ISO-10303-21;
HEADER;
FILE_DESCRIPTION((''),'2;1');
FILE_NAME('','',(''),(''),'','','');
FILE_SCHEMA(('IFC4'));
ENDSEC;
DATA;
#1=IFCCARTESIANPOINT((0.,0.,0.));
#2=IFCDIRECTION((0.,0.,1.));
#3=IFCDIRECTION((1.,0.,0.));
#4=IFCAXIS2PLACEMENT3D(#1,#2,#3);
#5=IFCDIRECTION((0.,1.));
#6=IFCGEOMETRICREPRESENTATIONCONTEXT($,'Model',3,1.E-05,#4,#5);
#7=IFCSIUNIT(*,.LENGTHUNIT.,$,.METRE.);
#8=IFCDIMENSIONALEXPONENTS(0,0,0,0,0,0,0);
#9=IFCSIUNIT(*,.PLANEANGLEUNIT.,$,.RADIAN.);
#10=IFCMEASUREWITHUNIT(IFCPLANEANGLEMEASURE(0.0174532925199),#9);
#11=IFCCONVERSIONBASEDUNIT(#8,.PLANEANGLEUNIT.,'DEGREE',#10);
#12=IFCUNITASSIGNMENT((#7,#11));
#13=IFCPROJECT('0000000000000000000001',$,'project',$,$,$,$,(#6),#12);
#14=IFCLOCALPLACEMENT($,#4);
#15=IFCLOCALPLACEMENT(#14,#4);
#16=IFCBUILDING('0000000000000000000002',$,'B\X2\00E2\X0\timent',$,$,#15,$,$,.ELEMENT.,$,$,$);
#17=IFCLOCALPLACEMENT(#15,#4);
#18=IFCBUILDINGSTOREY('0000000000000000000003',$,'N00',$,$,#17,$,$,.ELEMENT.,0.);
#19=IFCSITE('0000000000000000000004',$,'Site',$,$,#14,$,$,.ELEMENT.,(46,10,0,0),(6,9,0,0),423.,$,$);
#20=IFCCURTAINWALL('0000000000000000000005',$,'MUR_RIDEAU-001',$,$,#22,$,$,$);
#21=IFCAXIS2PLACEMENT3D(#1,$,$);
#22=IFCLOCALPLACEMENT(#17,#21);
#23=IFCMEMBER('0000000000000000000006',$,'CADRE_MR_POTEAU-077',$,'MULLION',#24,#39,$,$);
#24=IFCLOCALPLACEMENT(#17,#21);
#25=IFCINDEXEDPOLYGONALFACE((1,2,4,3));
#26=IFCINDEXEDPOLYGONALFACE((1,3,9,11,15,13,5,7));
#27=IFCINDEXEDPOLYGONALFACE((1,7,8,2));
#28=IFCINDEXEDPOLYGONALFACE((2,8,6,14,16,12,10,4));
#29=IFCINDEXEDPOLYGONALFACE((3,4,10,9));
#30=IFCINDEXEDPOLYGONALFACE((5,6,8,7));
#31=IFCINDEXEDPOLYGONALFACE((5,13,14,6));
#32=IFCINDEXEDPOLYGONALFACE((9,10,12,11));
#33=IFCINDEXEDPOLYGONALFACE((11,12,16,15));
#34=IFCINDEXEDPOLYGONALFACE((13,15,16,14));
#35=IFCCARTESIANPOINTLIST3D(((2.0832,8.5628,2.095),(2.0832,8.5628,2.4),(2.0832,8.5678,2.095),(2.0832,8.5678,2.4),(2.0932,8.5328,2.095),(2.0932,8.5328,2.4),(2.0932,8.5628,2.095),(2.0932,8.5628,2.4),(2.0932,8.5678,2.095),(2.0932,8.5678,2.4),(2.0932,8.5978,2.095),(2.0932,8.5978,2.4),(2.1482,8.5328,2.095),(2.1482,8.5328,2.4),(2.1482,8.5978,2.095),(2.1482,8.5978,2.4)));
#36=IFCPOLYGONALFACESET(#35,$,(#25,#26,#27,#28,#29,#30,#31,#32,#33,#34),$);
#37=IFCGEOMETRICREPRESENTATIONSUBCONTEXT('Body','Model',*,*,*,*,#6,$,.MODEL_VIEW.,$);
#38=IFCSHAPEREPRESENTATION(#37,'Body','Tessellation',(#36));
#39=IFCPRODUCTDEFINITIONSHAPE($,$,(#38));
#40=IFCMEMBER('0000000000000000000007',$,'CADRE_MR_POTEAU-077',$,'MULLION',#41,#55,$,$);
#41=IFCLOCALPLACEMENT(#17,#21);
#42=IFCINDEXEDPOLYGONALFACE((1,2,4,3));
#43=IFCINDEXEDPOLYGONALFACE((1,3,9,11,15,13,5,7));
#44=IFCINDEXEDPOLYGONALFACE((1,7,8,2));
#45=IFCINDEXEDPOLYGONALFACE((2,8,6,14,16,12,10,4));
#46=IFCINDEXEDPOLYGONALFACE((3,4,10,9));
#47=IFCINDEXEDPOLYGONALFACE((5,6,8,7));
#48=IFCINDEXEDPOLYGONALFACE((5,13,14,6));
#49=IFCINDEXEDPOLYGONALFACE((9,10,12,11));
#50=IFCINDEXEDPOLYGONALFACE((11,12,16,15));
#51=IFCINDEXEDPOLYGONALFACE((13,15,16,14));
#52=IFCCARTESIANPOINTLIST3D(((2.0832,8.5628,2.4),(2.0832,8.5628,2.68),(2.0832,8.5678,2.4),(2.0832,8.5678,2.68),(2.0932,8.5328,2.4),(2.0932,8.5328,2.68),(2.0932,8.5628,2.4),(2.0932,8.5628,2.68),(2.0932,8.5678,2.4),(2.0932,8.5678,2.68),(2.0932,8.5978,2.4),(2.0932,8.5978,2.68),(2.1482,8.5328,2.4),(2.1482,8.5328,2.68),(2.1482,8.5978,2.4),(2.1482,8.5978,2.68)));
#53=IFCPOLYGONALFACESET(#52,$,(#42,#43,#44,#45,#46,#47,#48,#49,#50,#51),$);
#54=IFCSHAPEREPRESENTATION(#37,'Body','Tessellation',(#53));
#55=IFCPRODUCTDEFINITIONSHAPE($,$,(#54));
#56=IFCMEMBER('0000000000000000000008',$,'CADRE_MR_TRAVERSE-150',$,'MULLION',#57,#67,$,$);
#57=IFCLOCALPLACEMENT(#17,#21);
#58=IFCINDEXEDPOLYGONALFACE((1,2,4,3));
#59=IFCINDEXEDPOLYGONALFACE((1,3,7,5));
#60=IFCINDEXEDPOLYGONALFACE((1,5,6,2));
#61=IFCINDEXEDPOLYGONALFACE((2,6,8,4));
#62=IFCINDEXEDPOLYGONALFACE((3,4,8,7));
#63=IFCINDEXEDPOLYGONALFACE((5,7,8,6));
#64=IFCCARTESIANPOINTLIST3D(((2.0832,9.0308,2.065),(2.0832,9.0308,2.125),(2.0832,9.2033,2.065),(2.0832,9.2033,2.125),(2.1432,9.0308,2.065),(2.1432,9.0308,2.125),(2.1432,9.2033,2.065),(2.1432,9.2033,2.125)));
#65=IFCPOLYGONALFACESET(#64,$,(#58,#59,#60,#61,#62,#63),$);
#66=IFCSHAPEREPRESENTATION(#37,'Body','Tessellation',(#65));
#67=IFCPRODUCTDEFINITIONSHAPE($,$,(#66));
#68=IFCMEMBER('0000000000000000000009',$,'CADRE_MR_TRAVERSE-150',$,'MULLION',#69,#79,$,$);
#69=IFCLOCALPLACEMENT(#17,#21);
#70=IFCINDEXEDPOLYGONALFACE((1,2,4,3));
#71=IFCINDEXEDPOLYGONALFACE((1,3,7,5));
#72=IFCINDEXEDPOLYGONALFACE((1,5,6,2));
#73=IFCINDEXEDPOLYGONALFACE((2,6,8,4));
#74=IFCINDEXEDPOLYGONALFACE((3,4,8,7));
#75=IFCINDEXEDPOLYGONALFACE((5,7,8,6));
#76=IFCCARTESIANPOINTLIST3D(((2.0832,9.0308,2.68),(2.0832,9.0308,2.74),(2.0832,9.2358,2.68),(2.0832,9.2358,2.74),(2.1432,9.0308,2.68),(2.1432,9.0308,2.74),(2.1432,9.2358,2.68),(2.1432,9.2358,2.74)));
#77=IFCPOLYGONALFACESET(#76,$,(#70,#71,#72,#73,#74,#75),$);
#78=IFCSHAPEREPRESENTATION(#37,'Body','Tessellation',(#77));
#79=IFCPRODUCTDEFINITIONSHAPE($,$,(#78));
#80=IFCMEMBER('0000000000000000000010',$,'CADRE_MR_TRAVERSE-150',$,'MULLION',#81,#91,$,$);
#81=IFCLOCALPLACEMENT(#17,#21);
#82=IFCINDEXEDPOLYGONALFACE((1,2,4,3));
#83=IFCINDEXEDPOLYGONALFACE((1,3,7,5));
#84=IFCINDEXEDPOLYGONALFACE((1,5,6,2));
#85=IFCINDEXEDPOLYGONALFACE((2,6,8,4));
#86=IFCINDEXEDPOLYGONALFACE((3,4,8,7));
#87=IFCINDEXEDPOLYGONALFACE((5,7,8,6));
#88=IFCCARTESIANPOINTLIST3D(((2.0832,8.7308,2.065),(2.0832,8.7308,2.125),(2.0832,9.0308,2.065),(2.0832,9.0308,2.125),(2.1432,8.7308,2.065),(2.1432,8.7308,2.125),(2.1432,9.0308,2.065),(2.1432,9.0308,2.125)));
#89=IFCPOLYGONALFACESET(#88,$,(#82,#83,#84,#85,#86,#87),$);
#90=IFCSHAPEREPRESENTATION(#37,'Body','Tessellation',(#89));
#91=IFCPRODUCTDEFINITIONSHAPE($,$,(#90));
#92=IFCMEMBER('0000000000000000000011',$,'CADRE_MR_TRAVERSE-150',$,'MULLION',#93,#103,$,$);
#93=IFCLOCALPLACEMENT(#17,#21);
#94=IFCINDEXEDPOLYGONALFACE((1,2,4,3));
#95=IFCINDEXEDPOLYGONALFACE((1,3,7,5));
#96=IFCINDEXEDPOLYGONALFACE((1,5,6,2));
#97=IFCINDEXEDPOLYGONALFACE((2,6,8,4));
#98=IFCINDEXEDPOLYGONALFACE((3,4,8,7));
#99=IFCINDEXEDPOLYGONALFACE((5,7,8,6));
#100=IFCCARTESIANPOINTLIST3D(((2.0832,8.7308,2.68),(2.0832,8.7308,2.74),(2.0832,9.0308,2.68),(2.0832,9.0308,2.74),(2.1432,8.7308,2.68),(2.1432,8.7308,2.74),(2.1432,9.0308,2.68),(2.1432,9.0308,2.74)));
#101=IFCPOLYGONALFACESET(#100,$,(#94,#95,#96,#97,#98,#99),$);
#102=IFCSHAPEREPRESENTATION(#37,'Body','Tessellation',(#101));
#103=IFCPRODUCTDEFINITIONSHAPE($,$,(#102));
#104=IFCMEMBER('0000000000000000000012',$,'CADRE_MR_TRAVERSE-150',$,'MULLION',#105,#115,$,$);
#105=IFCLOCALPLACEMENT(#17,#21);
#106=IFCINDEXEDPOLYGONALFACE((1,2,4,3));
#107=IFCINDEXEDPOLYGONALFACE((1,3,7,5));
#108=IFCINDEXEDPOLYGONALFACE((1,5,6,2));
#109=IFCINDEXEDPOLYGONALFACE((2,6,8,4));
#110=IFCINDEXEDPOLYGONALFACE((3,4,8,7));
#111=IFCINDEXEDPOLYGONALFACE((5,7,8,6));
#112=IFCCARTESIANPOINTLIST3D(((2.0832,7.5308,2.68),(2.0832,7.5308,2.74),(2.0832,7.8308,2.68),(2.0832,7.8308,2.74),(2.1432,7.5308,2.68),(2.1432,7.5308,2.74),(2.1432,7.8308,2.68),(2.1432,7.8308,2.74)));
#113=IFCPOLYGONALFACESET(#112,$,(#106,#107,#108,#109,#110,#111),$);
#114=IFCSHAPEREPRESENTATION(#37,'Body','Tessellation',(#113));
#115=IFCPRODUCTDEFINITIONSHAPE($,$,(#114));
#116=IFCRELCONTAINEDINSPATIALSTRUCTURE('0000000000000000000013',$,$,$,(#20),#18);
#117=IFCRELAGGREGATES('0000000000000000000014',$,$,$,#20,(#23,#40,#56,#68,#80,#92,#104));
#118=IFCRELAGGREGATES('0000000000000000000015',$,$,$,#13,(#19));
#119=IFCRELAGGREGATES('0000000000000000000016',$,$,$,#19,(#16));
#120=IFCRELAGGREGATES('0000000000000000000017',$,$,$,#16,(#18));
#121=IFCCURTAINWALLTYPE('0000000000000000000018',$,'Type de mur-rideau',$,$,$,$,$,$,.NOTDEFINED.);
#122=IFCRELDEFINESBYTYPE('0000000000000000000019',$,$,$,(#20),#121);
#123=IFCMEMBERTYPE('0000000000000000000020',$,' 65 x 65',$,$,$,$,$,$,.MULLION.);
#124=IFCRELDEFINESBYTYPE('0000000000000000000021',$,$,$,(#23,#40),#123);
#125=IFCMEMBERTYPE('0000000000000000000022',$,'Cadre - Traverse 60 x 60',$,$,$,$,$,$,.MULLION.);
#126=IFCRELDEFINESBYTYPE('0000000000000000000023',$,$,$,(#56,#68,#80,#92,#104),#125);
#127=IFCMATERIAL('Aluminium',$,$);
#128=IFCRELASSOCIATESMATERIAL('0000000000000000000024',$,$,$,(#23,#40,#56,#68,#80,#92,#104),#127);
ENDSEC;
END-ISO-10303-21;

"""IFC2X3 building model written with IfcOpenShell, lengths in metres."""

from ifc_helpers import new_model, entity, si_unit, converted_unit, direction, frame, origin_with_axes, place, context, subcontext, project, spatial, polyline, outline, extrude, material, type_object, element, aggregate, save


model = new_model("IFC2X3")

# Units and contexts
model_context = context("Model", 3, precision=1e-05, world=origin_with_axes(), true_north=direction((0.0, 1.0)))
body_context = subcontext(model_context, "Body", "Model", "MODEL_VIEW")
ifc_project = project(units=[si_unit("LENGTHUNIT", "METRE"), converted_unit("PLANEANGLEUNIT", "DEGREE", entity("IfcPlaneAngleMeasure", 0.0174532925199), si_unit("PLANEANGLEUNIT", "RADIAN"), dimensions=[0, 0, 0, 0, 0, 0, 0])], contexts=[model_context])

# Site, building, storey
site_placement = place(None, origin_with_axes())
site = spatial("IfcSite", under=ifc_project, at=site_placement, Name="Site", CompositionType="ELEMENT", RefLatitude=(46, 10, 0, 0), RefLongitude=(6, 9, 0, 0), RefElevation=423.0)
building_placement = place(site_placement, origin_with_axes())
building = spatial("IfcBuilding", under=site, at=building_placement, Name="Bâtiment", CompositionType="ELEMENT")
storey_placement = place(building_placement, origin_with_axes())
storey = spatial("IfcBuildingStorey", under=building, at=storey_placement, Name="N00", CompositionType="ELEMENT", Elevation=0.0)

# Curtain wall, members
curtain_wall_type = type_object("IfcCurtainWallType", Name="Type de mur-rideau", PredefinedType="NOTDEFINED")
curtain_wall_placement = place(storey_placement, frame((2.0832, 6.4208, 0.0), z_axis=(0.0, 0.0, 1.0), x_axis=(1.0, 0.0, 0.0)))
curtain_wall = element("IfcCurtainWall", 1, at=curtain_wall_placement, inside=storey, type_object=curtain_wall_type, Name="MUR_RIDEAU-001")
ifc_material_1 = material(Name="Aluminium")
member_type_1 = type_object("IfcMemberType", Name=" 65 x 65", PredefinedType="MULLION")
member_1_placement = place(curtain_wall_placement, frame((0.0, 2.1445, 2.095), z_axis=(0.0, 0.0, 1.0), x_axis=(0.0, 1.0, 0.0)))
member_1 = element("IfcMember", 2, at=member_1_placement, type_object=member_type_1, material=ifc_material_1, Name="CADRE_MR_POTEAU-077", ObjectType="MULLION", context=body_context, shape_type="SweptSolid", body=[
    extrude(outline(polyline([(0.01, -0.0025), (0.01, -0.0325), (0.065, -0.0325), (0.065, 0.0325), (0.01, 0.0325), (0.01, 0.0025), (0.0, 0.0025), (0.0, -0.0025), (0.01, -0.0025)])), frame((0.0, 0.0, 0.0), z_axis=(0.0, 0.0, 1.0), x_axis=(0.0, -1.0, 0.0)), (0.0, 0.0, 1.0), 0.305),
])
member_2_placement = place(curtain_wall_placement, frame((0.0, 2.1445, 2.4), z_axis=(0.0, 0.0, 1.0), x_axis=(0.0, 1.0, 0.0)))
member_2 = element("IfcMember", 3, at=member_2_placement, type_object=member_type_1, material=ifc_material_1, Name="CADRE_MR_POTEAU-077", ObjectType="MULLION", context=body_context, shape_type="SweptSolid", body=[
    extrude(outline(polyline([(0.01, -0.0025), (0.01, -0.0325), (0.065, -0.0325), (0.065, 0.0325), (0.01, 0.0325), (0.01, 0.0025), (0.0, 0.0025), (0.0, -0.0025), (0.01, -0.0025)])), frame((0.0, 0.0, 0.0), z_axis=(0.0, 0.0, 1.0), x_axis=(0.0, -1.0, 0.0)), (0.0, 0.0, 1.0), 0.28),
])
member_type_2 = type_object("IfcMemberType", Name="Cadre - Traverse 60 x 60", PredefinedType="MULLION")
member_3_placement = place(curtain_wall_placement, frame((0.0, 2.8149, 2.095), z_axis=(0.0, -1.0, 0.0), x_axis=(0.0, 0.0, 1.0)))
member_3 = element("IfcMember", 4, at=member_3_placement, type_object=member_type_2, material=ifc_material_1, Name="CADRE_MR_TRAVERSE-150", ObjectType="MULLION", context=body_context, shape_type="SweptSolid", body=[
    extrude(outline(polyline([(-0.06, -0.03), (0.0, -0.03), (0.0, 0.03), (-0.06, 0.03), (-0.06, -0.03)])), frame((0.0, 0.0, 0.0325), z_axis=(0.0, 0.0, 1.0), x_axis=(0.0, 1.0, 0.0)), (0.0, 0.0, 1.0), 0.1725),
])
member_4_placement = place(curtain_wall_placement, frame((0.0, 2.8149, 2.71), z_axis=(0.0, -1.0, 0.0), x_axis=(0.0, 0.0, 1.0)))
member_4 = element("IfcMember", 5, at=member_4_placement, type_object=member_type_2, material=ifc_material_1, Name="CADRE_MR_TRAVERSE-150", ObjectType="MULLION", context=body_context, shape_type="SweptSolid", body=[
    extrude(outline(polyline([(-0.06, -0.03), (0.0, -0.03), (0.0, 0.03), (-0.06, 0.03), (-0.06, -0.03)])), frame((0.0, 0.0, 0.0), z_axis=(0.0, 0.0, 1.0), x_axis=(0.0, 1.0, 0.0)), (0.0, 0.0, 1.0), 0.205),
])
member_5_placement = place(curtain_wall_placement, frame((0.0, 2.6099, 2.095), z_axis=(0.0, -1.0, 0.0), x_axis=(0.0, 0.0, 1.0)))
member_5 = element("IfcMember", 6, at=member_5_placement, type_object=member_type_2, material=ifc_material_1, Name="CADRE_MR_TRAVERSE-150", ObjectType="MULLION", context=body_context, shape_type="SweptSolid", body=[
    extrude(outline(polyline([(-0.06, -0.03), (0.0, -0.03), (0.0, 0.03), (-0.06, 0.03), (-0.06, -0.03)])), frame((0.0, 0.0, 0.0), z_axis=(0.0, 0.0, 1.0), x_axis=(0.0, 1.0, 0.0)), (0.0, 0.0, 1.0), 0.3),
])
member_6_placement = place(curtain_wall_placement, frame((0.0, 2.6099, 2.71), z_axis=(0.0, -1.0, 0.0), x_axis=(0.0, 0.0, 1.0)))
member_6 = element("IfcMember", 7, at=member_6_placement, type_object=member_type_2, material=ifc_material_1, Name="CADRE_MR_TRAVERSE-150", ObjectType="MULLION", context=body_context, shape_type="SweptSolid", body=[
    extrude(outline(polyline([(-0.06, -0.03), (0.0, -0.03), (0.0, 0.03), (-0.06, 0.03), (-0.06, -0.03)])), frame((0.0, 0.0, 0.0), z_axis=(0.0, 0.0, 1.0), x_axis=(0.0, 1.0, 0.0)), (0.0, 0.0, 1.0), 0.3),
])
member_7_placement = place(curtain_wall_placement, frame((0.0, 1.4099, 2.71), z_axis=(0.0, -1.0, 0.0), x_axis=(0.0, 0.0, 1.0)))
member_7 = element("IfcMember", 8, at=member_7_placement, type_object=member_type_2, material=ifc_material_1, Name="CADRE_MR_TRAVERSE-150", ObjectType="MULLION", context=body_context, shape_type="SweptSolid", body=[
    extrude(outline(polyline([(-0.06, -0.03), (0.0, -0.03), (0.0, 0.03), (-0.06, 0.03), (-0.06, -0.03)])), frame((0.0, 0.0, 0.0), z_axis=(0.0, 0.0, 1.0), x_axis=(0.0, 1.0, 0.0)), (0.0, 0.0, 1.0), 0.3),
])
aggregate(curtain_wall, [member_1, member_2, member_3, member_4, member_5, member_6, member_7])

save(model, "model.ifc")
